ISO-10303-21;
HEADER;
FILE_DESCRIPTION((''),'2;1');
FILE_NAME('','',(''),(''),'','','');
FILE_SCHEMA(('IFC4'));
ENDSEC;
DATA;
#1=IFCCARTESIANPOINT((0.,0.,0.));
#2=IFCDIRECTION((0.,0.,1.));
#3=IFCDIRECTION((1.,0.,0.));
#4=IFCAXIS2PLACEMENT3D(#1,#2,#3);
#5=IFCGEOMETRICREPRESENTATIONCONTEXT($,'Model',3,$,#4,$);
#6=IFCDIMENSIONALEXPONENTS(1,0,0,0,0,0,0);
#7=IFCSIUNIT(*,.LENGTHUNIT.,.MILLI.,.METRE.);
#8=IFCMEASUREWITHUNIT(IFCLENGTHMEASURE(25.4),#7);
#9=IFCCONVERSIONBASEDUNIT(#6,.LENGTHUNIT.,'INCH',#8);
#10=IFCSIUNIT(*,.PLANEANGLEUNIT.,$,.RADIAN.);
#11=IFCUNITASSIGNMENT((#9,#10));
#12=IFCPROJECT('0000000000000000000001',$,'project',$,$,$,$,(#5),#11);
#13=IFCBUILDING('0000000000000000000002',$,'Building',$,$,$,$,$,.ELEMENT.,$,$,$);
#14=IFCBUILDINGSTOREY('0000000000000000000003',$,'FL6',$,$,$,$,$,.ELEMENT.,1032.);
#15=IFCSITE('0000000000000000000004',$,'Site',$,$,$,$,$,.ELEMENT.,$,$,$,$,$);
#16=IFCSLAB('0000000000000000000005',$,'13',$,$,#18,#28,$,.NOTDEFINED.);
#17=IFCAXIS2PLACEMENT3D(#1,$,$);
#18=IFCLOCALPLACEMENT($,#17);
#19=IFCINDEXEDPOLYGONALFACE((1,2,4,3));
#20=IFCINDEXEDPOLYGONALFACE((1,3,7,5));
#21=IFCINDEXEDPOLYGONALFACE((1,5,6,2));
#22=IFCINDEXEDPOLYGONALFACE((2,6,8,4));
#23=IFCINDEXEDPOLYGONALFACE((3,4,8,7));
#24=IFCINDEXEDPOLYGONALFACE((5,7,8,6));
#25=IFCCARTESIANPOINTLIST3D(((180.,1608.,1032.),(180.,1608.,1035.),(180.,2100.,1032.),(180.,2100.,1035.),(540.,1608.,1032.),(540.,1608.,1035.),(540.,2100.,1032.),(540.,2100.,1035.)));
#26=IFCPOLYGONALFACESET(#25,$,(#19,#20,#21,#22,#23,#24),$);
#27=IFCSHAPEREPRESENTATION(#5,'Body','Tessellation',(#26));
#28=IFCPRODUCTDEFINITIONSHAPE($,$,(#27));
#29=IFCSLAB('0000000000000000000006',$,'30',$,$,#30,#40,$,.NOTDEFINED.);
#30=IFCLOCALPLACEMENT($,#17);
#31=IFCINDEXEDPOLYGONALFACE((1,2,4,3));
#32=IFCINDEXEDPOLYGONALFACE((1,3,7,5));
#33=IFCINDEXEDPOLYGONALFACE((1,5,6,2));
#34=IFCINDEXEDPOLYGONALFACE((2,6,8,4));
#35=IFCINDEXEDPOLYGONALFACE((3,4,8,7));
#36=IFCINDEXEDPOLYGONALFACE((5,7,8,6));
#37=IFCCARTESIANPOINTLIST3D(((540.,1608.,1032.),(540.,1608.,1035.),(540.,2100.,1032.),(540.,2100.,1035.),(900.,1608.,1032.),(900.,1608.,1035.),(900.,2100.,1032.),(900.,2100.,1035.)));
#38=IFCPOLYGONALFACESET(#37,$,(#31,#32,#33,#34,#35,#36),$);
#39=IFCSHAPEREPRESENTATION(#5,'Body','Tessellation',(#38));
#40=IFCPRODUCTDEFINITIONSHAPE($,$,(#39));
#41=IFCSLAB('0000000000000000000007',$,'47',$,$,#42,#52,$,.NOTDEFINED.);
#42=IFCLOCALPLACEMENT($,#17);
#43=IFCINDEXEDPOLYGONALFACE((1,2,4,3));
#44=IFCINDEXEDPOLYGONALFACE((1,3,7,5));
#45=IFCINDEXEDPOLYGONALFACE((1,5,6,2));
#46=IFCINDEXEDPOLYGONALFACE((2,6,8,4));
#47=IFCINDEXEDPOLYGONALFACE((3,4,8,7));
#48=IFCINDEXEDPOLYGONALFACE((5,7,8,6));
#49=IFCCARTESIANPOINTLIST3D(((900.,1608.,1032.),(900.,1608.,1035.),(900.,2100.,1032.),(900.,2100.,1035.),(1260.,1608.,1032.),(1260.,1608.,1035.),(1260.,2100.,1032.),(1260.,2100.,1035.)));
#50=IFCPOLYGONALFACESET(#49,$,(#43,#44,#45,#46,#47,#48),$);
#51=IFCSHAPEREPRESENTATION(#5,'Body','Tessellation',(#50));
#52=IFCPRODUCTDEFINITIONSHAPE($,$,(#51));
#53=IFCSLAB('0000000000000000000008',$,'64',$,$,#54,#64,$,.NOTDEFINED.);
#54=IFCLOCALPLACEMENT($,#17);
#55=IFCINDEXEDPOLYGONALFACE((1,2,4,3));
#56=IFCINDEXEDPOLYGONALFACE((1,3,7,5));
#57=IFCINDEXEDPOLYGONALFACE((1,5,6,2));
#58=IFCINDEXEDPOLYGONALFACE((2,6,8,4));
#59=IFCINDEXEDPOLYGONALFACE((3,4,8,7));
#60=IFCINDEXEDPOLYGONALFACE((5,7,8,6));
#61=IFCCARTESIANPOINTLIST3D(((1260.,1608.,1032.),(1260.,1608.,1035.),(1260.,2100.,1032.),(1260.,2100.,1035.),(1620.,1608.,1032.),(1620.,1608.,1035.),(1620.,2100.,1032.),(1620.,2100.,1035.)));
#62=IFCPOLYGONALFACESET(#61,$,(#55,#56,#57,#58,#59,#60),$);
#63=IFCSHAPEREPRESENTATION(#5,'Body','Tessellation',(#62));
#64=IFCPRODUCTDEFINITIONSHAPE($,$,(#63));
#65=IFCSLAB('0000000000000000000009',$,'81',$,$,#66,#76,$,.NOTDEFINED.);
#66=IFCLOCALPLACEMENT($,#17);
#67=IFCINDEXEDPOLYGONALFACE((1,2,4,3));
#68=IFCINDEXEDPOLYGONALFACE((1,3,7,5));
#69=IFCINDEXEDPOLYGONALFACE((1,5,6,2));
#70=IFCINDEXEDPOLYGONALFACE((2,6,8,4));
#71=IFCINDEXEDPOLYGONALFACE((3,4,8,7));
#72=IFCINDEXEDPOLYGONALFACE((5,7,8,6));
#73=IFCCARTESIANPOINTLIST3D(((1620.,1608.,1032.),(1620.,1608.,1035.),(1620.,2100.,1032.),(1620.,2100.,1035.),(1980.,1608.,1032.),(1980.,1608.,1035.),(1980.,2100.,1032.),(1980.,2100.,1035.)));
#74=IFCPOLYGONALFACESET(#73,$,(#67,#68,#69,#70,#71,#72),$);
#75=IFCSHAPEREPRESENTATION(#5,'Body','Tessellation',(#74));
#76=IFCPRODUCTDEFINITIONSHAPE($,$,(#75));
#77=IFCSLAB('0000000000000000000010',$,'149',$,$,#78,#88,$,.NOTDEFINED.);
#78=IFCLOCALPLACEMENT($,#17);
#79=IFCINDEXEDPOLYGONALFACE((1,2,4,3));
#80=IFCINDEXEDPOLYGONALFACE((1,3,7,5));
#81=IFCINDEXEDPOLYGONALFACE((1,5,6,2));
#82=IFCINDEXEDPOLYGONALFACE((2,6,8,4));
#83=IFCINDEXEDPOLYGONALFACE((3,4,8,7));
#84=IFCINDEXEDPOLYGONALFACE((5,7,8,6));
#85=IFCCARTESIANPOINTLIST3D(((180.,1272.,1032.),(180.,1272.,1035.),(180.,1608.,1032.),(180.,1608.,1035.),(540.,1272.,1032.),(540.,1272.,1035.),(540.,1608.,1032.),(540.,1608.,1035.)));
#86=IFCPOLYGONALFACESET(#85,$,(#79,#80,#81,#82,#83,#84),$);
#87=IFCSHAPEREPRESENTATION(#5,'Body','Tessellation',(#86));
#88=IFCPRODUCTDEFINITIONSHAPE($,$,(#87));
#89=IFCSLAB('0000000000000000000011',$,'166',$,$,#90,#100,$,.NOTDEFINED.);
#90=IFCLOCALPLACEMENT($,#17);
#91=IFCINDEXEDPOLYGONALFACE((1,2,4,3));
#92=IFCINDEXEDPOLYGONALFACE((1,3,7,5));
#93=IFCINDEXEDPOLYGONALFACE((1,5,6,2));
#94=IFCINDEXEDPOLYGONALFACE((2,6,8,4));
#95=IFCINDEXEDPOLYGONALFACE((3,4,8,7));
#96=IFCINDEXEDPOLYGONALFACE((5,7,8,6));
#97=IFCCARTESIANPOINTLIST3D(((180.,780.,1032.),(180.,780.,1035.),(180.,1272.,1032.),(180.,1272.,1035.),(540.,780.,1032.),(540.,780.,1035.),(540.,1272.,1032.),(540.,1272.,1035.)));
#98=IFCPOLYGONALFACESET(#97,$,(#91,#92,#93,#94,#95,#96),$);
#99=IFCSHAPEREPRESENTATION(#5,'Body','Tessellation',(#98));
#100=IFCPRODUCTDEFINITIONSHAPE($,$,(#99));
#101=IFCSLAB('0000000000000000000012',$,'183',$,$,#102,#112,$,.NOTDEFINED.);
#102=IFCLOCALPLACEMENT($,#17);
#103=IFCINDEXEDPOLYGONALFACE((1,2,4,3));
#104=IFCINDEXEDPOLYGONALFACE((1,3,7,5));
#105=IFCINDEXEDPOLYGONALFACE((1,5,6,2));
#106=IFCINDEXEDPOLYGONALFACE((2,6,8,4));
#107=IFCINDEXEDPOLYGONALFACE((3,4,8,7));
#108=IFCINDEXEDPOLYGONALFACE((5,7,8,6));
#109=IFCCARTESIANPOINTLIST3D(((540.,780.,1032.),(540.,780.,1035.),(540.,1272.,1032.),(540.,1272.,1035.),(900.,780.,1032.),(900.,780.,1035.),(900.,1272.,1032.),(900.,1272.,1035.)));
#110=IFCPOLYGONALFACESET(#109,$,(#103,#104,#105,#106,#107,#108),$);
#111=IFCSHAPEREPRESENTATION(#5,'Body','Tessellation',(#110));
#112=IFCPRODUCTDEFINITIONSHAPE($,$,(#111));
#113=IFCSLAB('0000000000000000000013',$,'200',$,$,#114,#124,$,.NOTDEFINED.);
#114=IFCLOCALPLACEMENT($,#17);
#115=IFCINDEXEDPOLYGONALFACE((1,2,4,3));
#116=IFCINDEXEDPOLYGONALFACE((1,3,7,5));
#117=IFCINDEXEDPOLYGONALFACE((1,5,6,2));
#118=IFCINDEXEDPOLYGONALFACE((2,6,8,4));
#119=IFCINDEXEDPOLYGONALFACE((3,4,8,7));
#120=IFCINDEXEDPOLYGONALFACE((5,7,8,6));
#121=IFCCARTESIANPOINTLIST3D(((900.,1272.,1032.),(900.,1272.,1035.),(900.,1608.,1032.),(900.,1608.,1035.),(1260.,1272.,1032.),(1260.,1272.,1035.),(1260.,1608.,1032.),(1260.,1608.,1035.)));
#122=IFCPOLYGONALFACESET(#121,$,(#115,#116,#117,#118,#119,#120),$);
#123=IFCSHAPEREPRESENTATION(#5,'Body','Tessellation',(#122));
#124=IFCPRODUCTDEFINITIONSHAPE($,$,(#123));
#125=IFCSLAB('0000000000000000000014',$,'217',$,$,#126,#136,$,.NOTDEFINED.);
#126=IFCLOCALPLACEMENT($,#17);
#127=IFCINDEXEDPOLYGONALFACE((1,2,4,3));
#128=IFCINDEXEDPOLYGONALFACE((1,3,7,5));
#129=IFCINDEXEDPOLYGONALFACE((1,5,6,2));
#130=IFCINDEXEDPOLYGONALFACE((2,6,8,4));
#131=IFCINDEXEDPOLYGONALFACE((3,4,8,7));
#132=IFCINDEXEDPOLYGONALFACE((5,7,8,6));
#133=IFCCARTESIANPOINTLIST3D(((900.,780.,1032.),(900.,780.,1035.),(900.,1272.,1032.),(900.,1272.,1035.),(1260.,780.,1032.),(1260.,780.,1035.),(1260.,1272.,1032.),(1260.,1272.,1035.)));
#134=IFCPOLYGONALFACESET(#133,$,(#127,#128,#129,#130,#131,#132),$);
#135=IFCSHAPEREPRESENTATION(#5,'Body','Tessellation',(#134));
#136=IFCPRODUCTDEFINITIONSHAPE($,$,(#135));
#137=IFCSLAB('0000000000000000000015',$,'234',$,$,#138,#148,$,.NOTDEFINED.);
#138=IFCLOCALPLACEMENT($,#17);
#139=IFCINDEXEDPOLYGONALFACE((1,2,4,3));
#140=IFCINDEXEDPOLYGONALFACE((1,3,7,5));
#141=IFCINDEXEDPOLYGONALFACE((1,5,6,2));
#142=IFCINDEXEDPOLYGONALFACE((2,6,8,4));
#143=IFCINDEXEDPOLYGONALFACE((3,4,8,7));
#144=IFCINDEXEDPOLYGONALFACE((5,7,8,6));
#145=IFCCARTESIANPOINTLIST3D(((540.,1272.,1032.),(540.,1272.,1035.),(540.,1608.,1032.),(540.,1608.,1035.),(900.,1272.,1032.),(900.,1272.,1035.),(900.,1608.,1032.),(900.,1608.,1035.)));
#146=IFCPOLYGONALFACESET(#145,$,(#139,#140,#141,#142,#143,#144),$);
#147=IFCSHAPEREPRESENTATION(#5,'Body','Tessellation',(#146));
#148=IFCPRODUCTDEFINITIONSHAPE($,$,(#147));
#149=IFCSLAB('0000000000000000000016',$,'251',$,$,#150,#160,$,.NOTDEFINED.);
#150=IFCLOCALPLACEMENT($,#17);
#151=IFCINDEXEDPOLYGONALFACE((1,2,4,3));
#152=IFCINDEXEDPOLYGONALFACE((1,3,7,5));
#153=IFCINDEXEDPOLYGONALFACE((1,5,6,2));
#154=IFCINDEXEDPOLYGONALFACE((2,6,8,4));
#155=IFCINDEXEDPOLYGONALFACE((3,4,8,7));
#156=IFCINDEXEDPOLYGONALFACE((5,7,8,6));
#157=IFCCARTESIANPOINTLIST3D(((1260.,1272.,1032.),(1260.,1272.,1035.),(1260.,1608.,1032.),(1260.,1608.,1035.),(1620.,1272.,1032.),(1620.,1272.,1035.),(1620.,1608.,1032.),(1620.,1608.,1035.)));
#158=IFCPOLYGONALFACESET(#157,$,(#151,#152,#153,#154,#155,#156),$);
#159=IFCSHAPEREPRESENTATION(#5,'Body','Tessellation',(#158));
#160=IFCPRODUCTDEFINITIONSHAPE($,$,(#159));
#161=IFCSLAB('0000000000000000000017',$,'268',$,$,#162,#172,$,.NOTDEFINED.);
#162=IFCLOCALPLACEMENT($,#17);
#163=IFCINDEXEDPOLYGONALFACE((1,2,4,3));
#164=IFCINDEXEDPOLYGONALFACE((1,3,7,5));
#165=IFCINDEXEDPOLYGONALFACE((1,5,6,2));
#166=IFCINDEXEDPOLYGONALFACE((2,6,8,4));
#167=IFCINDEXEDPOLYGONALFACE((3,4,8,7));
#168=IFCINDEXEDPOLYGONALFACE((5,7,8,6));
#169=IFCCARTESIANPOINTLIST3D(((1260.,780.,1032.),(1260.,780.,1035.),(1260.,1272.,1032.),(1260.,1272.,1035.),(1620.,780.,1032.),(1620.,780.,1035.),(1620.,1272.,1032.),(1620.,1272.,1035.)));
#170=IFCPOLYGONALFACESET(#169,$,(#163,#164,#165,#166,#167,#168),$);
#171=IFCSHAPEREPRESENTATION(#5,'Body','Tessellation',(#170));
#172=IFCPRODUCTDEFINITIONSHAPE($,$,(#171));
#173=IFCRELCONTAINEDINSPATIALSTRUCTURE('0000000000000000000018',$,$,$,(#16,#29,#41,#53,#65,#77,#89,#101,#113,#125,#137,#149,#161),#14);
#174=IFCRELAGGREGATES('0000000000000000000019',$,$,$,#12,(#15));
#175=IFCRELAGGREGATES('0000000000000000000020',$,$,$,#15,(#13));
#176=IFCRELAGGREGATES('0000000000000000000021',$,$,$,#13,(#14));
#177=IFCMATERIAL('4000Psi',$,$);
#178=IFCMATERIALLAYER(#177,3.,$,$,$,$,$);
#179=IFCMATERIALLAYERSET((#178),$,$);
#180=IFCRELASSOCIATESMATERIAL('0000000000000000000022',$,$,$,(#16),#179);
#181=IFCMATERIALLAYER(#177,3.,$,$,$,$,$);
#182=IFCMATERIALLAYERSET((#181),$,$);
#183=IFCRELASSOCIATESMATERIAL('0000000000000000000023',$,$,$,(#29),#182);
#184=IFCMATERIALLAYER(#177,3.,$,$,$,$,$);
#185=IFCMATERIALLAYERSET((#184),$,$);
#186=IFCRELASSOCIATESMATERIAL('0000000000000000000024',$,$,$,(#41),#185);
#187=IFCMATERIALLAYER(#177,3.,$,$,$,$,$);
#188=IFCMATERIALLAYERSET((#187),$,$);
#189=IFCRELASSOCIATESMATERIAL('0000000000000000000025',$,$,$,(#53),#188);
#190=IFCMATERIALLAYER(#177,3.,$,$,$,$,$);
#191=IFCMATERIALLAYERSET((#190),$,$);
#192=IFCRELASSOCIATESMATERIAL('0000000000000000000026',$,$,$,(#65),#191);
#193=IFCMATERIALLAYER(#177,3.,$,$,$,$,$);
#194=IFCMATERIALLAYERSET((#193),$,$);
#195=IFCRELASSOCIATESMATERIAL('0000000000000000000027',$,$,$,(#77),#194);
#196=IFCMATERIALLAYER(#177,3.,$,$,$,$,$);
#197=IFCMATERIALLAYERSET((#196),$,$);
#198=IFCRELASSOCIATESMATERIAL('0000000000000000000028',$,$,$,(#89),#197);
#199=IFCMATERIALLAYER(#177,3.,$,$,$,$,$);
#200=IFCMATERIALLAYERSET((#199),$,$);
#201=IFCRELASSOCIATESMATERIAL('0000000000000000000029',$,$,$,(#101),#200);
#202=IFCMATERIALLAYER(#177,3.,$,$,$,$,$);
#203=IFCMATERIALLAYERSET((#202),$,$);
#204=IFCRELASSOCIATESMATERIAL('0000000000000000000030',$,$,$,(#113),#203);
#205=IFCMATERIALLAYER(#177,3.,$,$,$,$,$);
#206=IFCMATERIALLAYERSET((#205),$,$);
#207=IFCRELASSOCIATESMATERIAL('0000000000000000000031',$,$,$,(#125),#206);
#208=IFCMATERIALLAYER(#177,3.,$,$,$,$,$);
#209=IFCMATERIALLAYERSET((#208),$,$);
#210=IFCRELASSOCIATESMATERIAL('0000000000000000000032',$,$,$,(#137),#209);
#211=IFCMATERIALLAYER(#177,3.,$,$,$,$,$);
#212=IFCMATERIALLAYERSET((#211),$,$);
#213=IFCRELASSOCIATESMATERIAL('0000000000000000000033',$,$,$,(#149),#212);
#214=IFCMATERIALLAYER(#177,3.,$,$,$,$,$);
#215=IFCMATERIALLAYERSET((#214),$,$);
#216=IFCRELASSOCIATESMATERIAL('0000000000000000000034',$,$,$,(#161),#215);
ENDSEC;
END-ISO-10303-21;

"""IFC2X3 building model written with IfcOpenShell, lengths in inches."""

from ifc_helpers import new_model, entity, si_unit, converted_unit, frame, origin_with_axes, place, context, project, spatial, polyline, outline, extrude, material, layer, layer_set, layer_usage, element, save


model = new_model("IFC2X3")

# Units and contexts
model_context = context("Model", 3, world=origin_with_axes())
ifc_project = project(units=[converted_unit("LENGTHUNIT", "INCH", entity("IfcLengthMeasure", 25.4), si_unit("LENGTHUNIT", "METRE", prefix="MILLI"), dimensions=[1, 0, 0, 0, 0, 0, 0]), si_unit("PLANEANGLEUNIT", "RADIAN")], contexts=[model_context])

# Site, building, storey
site = spatial("IfcSite", under=ifc_project, Name="Site", CompositionType="ELEMENT")
building = spatial("IfcBuilding", under=site, Name="Building", CompositionType="ELEMENT")
storey = spatial("IfcBuildingStorey", under=building, Name="FL6", CompositionType="ELEMENT", Elevation=1032.0)

# Slabs
ifc_material_1 = material(Name="4000Psi")
ifc_layer_1 = layer(ifc_material_1, 3.0)
ifc_layer_set_1 = layer_set([ifc_layer_1])
ifc_layer_usage_1 = layer_usage(ifc_layer_set_1, "AXIS2", "POSITIVE", -3.0)
slab_1_placement = place(None, frame((180.0, 1608.0, 1032.0), z_axis=(0.0, 0.0, 1.0), x_axis=(1.0, 0.0, 0.0)))
element("IfcSlab", 1, at=slab_1_placement, inside=storey, material=ifc_layer_usage_1, Name="13", PredefinedType="NOTDEFINED", context=model_context, shape_type="SweptSolid", body=[
    extrude(outline(polyline([(0.0, 0.0), (360.0, 0.0), (360.0, 492.0), (0.0, 492.0), (0.0, 0.0)])), origin_with_axes(), (0.0, 0.0, 1.0), 3.0),
])
ifc_layer_2 = layer(ifc_material_1, 3.0)
ifc_layer_set_2 = layer_set([ifc_layer_2])
ifc_layer_usage_2 = layer_usage(ifc_layer_set_2, "AXIS2", "POSITIVE", -3.0)
slab_2_placement = place(None, frame((540.0, 1608.0, 1032.0), z_axis=(0.0, 0.0, 1.0), x_axis=(1.0, 0.0, 0.0)))
element("IfcSlab", 2, at=slab_2_placement, inside=storey, material=ifc_layer_usage_2, Name="30", PredefinedType="NOTDEFINED", context=model_context, shape_type="SweptSolid", body=[
    extrude(outline(polyline([(0.0, 0.0), (360.0, 0.0), (360.0, 492.0), (0.0, 492.0), (0.0, 0.0)])), origin_with_axes(), (0.0, 0.0, 1.0), 3.0),
])
ifc_layer_3 = layer(ifc_material_1, 3.0)
ifc_layer_set_3 = layer_set([ifc_layer_3])
ifc_layer_usage_3 = layer_usage(ifc_layer_set_3, "AXIS2", "POSITIVE", -3.0)
slab_3_placement = place(None, frame((900.0, 1608.0, 1032.0), z_axis=(0.0, 0.0, 1.0), x_axis=(1.0, 0.0, 0.0)))
element("IfcSlab", 3, at=slab_3_placement, inside=storey, material=ifc_layer_usage_3, Name="47", PredefinedType="NOTDEFINED", context=model_context, shape_type="SweptSolid", body=[
    extrude(outline(polyline([(0.0, 0.0), (360.0, 0.0), (360.0, 492.0), (0.0, 492.0), (0.0, 0.0)])), origin_with_axes(), (0.0, 0.0, 1.0), 3.0),
])
ifc_layer_4 = layer(ifc_material_1, 3.0)
ifc_layer_set_4 = layer_set([ifc_layer_4])
ifc_layer_usage_4 = layer_usage(ifc_layer_set_4, "AXIS2", "POSITIVE", -3.0)
slab_4_placement = place(None, frame((1260.0, 1608.0, 1032.0), z_axis=(0.0, 0.0, 1.0), x_axis=(1.0, 0.0, 0.0)))
element("IfcSlab", 4, at=slab_4_placement, inside=storey, material=ifc_layer_usage_4, Name="64", PredefinedType="NOTDEFINED", context=model_context, shape_type="SweptSolid", body=[
    extrude(outline(polyline([(0.0, 0.0), (360.0, 0.0), (360.0, 492.0), (0.0, 492.0), (0.0, 0.0)])), origin_with_axes(), (0.0, 0.0, 1.0), 3.0),
])
ifc_layer_5 = layer(ifc_material_1, 3.0)
ifc_layer_set_5 = layer_set([ifc_layer_5])
ifc_layer_usage_5 = layer_usage(ifc_layer_set_5, "AXIS2", "POSITIVE", -3.0)
slab_5_placement = place(None, frame((1620.0, 1608.0, 1032.0), z_axis=(0.0, 0.0, 1.0), x_axis=(1.0, 0.0, 0.0)))
element("IfcSlab", 5, at=slab_5_placement, inside=storey, material=ifc_layer_usage_5, Name="81", PredefinedType="NOTDEFINED", context=model_context, shape_type="SweptSolid", body=[
    extrude(outline(polyline([(0.0, 0.0), (360.0, 0.0), (360.0, 492.0), (0.0, 492.0), (0.0, 0.0)])), origin_with_axes(), (0.0, 0.0, 1.0), 3.0),
])
ifc_layer_6 = layer(ifc_material_1, 3.0)
ifc_layer_set_6 = layer_set([ifc_layer_6])
ifc_layer_usage_6 = layer_usage(ifc_layer_set_6, "AXIS2", "POSITIVE", -3.0)
slab_6_placement = place(None, frame((180.0, 1272.0, 1032.0), z_axis=(0.0, 0.0, 1.0), x_axis=(1.0, 0.0, 0.0)))
element("IfcSlab", 6, at=slab_6_placement, inside=storey, material=ifc_layer_usage_6, Name="149", PredefinedType="NOTDEFINED", context=model_context, shape_type="SweptSolid", body=[
    extrude(outline(polyline([(0.0, 0.0), (360.0, 0.0), (360.0, 336.0), (0.0, 336.0), (0.0, 0.0)])), origin_with_axes(), (0.0, 0.0, 1.0), 3.0),
])
ifc_layer_7 = layer(ifc_material_1, 3.0)
ifc_layer_set_7 = layer_set([ifc_layer_7])
ifc_layer_usage_7 = layer_usage(ifc_layer_set_7, "AXIS2", "POSITIVE", -3.0)
slab_7_placement = place(None, frame((180.0, 780.0, 1032.0), z_axis=(0.0, 0.0, 1.0), x_axis=(1.0, 0.0, 0.0)))
element("IfcSlab", 7, at=slab_7_placement, inside=storey, material=ifc_layer_usage_7, Name="166", PredefinedType="NOTDEFINED", context=model_context, shape_type="SweptSolid", body=[
    extrude(outline(polyline([(0.0, 0.0), (360.0, 0.0), (360.0, 492.0), (0.0, 492.0), (0.0, 0.0)])), origin_with_axes(), (0.0, 0.0, 1.0), 3.0),
])
ifc_layer_8 = layer(ifc_material_1, 3.0)
ifc_layer_set_8 = layer_set([ifc_layer_8])
ifc_layer_usage_8 = layer_usage(ifc_layer_set_8, "AXIS2", "POSITIVE", -3.0)
slab_8_placement = place(None, frame((540.0, 780.0, 1032.0), z_axis=(0.0, 0.0, 1.0), x_axis=(1.0, 0.0, 0.0)))
element("IfcSlab", 8, at=slab_8_placement, inside=storey, material=ifc_layer_usage_8, Name="183", PredefinedType="NOTDEFINED", context=model_context, shape_type="SweptSolid", body=[
    extrude(outline(polyline([(0.0, 0.0), (360.0, 0.0), (360.0, 492.0), (0.0, 492.0), (0.0, 0.0)])), origin_with_axes(), (0.0, 0.0, 1.0), 3.0),
])
ifc_layer_9 = layer(ifc_material_1, 3.0)
ifc_layer_set_9 = layer_set([ifc_layer_9])
ifc_layer_usage_9 = layer_usage(ifc_layer_set_9, "AXIS2", "POSITIVE", -3.0)
slab_9_placement = place(None, frame((900.0, 1272.0, 1032.0), z_axis=(0.0, 0.0, 1.0), x_axis=(1.0, 0.0, 0.0)))
element("IfcSlab", 9, at=slab_9_placement, inside=storey, material=ifc_layer_usage_9, Name="200", PredefinedType="NOTDEFINED", context=model_context, shape_type="SweptSolid", body=[
    extrude(outline(polyline([(0.0, 0.0), (360.0, 0.0), (360.0, 336.0), (0.0, 336.0), (0.0, 0.0)])), origin_with_axes(), (0.0, 0.0, 1.0), 3.0),
])
ifc_layer_10 = layer(ifc_material_1, 3.0)
ifc_layer_set_10 = layer_set([ifc_layer_10])
ifc_layer_usage_10 = layer_usage(ifc_layer_set_10, "AXIS2", "POSITIVE", -3.0)
slab_10_placement = place(None, frame((900.0, 780.0, 1032.0), z_axis=(0.0, 0.0, 1.0), x_axis=(1.0, 0.0, 0.0)))
element("IfcSlab", 10, at=slab_10_placement, inside=storey, material=ifc_layer_usage_10, Name="217", PredefinedType="NOTDEFINED", context=model_context, shape_type="SweptSolid", body=[
    extrude(outline(polyline([(0.0, 0.0), (360.0, 0.0), (360.0, 492.0), (0.0, 492.0), (0.0, 0.0)])), origin_with_axes(), (0.0, 0.0, 1.0), 3.0),
])
ifc_layer_11 = layer(ifc_material_1, 3.0)
ifc_layer_set_11 = layer_set([ifc_layer_11])
ifc_layer_usage_11 = layer_usage(ifc_layer_set_11, "AXIS2", "POSITIVE", -3.0)
slab_11_placement = place(None, frame((540.0, 1272.0, 1032.0), z_axis=(0.0, 0.0, 1.0), x_axis=(1.0, 0.0, 0.0)))
element("IfcSlab", 11, at=slab_11_placement, inside=storey, material=ifc_layer_usage_11, Name="234", PredefinedType="NOTDEFINED", context=model_context, shape_type="SweptSolid", body=[
    extrude(outline(polyline([(0.0, 0.0), (360.0, 0.0), (360.0, 336.0), (0.0, 336.0), (0.0, 0.0)])), origin_with_axes(), (0.0, 0.0, 1.0), 3.0),
])
ifc_layer_12 = layer(ifc_material_1, 3.0)
ifc_layer_set_12 = layer_set([ifc_layer_12])
ifc_layer_usage_12 = layer_usage(ifc_layer_set_12, "AXIS2", "POSITIVE", -3.0)
slab_12_placement = place(None, frame((1260.0, 1272.0, 1032.0), z_axis=(0.0, 0.0, 1.0), x_axis=(1.0, 0.0, 0.0)))
element("IfcSlab", 12, at=slab_12_placement, inside=storey, material=ifc_layer_usage_12, Name="251", PredefinedType="NOTDEFINED", context=model_context, shape_type="SweptSolid", body=[
    extrude(outline(polyline([(0.0, 0.0), (360.0, 0.0), (360.0, 336.0), (0.0, 336.0), (0.0, 0.0)])), origin_with_axes(), (0.0, 0.0, 1.0), 3.0),
])
ifc_layer_13 = layer(ifc_material_1, 3.0)
ifc_layer_set_13 = layer_set([ifc_layer_13])
ifc_layer_usage_13 = layer_usage(ifc_layer_set_13, "AXIS2", "POSITIVE", -3.0)
slab_13_placement = place(None, frame((1260.0, 780.0, 1032.0), z_axis=(0.0, 0.0, 1.0), x_axis=(1.0, 0.0, 0.0)))
element("IfcSlab", 13, at=slab_13_placement, inside=storey, material=ifc_layer_usage_13, Name="268", PredefinedType="NOTDEFINED", context=model_context, shape_type="SweptSolid", body=[
    extrude(outline(polyline([(0.0, 0.0), (360.0, 0.0), (360.0, 492.0), (0.0, 492.0), (0.0, 0.0)])), origin_with_axes(), (0.0, 0.0, 1.0), 3.0),
])

save(model, "model.ifc")
